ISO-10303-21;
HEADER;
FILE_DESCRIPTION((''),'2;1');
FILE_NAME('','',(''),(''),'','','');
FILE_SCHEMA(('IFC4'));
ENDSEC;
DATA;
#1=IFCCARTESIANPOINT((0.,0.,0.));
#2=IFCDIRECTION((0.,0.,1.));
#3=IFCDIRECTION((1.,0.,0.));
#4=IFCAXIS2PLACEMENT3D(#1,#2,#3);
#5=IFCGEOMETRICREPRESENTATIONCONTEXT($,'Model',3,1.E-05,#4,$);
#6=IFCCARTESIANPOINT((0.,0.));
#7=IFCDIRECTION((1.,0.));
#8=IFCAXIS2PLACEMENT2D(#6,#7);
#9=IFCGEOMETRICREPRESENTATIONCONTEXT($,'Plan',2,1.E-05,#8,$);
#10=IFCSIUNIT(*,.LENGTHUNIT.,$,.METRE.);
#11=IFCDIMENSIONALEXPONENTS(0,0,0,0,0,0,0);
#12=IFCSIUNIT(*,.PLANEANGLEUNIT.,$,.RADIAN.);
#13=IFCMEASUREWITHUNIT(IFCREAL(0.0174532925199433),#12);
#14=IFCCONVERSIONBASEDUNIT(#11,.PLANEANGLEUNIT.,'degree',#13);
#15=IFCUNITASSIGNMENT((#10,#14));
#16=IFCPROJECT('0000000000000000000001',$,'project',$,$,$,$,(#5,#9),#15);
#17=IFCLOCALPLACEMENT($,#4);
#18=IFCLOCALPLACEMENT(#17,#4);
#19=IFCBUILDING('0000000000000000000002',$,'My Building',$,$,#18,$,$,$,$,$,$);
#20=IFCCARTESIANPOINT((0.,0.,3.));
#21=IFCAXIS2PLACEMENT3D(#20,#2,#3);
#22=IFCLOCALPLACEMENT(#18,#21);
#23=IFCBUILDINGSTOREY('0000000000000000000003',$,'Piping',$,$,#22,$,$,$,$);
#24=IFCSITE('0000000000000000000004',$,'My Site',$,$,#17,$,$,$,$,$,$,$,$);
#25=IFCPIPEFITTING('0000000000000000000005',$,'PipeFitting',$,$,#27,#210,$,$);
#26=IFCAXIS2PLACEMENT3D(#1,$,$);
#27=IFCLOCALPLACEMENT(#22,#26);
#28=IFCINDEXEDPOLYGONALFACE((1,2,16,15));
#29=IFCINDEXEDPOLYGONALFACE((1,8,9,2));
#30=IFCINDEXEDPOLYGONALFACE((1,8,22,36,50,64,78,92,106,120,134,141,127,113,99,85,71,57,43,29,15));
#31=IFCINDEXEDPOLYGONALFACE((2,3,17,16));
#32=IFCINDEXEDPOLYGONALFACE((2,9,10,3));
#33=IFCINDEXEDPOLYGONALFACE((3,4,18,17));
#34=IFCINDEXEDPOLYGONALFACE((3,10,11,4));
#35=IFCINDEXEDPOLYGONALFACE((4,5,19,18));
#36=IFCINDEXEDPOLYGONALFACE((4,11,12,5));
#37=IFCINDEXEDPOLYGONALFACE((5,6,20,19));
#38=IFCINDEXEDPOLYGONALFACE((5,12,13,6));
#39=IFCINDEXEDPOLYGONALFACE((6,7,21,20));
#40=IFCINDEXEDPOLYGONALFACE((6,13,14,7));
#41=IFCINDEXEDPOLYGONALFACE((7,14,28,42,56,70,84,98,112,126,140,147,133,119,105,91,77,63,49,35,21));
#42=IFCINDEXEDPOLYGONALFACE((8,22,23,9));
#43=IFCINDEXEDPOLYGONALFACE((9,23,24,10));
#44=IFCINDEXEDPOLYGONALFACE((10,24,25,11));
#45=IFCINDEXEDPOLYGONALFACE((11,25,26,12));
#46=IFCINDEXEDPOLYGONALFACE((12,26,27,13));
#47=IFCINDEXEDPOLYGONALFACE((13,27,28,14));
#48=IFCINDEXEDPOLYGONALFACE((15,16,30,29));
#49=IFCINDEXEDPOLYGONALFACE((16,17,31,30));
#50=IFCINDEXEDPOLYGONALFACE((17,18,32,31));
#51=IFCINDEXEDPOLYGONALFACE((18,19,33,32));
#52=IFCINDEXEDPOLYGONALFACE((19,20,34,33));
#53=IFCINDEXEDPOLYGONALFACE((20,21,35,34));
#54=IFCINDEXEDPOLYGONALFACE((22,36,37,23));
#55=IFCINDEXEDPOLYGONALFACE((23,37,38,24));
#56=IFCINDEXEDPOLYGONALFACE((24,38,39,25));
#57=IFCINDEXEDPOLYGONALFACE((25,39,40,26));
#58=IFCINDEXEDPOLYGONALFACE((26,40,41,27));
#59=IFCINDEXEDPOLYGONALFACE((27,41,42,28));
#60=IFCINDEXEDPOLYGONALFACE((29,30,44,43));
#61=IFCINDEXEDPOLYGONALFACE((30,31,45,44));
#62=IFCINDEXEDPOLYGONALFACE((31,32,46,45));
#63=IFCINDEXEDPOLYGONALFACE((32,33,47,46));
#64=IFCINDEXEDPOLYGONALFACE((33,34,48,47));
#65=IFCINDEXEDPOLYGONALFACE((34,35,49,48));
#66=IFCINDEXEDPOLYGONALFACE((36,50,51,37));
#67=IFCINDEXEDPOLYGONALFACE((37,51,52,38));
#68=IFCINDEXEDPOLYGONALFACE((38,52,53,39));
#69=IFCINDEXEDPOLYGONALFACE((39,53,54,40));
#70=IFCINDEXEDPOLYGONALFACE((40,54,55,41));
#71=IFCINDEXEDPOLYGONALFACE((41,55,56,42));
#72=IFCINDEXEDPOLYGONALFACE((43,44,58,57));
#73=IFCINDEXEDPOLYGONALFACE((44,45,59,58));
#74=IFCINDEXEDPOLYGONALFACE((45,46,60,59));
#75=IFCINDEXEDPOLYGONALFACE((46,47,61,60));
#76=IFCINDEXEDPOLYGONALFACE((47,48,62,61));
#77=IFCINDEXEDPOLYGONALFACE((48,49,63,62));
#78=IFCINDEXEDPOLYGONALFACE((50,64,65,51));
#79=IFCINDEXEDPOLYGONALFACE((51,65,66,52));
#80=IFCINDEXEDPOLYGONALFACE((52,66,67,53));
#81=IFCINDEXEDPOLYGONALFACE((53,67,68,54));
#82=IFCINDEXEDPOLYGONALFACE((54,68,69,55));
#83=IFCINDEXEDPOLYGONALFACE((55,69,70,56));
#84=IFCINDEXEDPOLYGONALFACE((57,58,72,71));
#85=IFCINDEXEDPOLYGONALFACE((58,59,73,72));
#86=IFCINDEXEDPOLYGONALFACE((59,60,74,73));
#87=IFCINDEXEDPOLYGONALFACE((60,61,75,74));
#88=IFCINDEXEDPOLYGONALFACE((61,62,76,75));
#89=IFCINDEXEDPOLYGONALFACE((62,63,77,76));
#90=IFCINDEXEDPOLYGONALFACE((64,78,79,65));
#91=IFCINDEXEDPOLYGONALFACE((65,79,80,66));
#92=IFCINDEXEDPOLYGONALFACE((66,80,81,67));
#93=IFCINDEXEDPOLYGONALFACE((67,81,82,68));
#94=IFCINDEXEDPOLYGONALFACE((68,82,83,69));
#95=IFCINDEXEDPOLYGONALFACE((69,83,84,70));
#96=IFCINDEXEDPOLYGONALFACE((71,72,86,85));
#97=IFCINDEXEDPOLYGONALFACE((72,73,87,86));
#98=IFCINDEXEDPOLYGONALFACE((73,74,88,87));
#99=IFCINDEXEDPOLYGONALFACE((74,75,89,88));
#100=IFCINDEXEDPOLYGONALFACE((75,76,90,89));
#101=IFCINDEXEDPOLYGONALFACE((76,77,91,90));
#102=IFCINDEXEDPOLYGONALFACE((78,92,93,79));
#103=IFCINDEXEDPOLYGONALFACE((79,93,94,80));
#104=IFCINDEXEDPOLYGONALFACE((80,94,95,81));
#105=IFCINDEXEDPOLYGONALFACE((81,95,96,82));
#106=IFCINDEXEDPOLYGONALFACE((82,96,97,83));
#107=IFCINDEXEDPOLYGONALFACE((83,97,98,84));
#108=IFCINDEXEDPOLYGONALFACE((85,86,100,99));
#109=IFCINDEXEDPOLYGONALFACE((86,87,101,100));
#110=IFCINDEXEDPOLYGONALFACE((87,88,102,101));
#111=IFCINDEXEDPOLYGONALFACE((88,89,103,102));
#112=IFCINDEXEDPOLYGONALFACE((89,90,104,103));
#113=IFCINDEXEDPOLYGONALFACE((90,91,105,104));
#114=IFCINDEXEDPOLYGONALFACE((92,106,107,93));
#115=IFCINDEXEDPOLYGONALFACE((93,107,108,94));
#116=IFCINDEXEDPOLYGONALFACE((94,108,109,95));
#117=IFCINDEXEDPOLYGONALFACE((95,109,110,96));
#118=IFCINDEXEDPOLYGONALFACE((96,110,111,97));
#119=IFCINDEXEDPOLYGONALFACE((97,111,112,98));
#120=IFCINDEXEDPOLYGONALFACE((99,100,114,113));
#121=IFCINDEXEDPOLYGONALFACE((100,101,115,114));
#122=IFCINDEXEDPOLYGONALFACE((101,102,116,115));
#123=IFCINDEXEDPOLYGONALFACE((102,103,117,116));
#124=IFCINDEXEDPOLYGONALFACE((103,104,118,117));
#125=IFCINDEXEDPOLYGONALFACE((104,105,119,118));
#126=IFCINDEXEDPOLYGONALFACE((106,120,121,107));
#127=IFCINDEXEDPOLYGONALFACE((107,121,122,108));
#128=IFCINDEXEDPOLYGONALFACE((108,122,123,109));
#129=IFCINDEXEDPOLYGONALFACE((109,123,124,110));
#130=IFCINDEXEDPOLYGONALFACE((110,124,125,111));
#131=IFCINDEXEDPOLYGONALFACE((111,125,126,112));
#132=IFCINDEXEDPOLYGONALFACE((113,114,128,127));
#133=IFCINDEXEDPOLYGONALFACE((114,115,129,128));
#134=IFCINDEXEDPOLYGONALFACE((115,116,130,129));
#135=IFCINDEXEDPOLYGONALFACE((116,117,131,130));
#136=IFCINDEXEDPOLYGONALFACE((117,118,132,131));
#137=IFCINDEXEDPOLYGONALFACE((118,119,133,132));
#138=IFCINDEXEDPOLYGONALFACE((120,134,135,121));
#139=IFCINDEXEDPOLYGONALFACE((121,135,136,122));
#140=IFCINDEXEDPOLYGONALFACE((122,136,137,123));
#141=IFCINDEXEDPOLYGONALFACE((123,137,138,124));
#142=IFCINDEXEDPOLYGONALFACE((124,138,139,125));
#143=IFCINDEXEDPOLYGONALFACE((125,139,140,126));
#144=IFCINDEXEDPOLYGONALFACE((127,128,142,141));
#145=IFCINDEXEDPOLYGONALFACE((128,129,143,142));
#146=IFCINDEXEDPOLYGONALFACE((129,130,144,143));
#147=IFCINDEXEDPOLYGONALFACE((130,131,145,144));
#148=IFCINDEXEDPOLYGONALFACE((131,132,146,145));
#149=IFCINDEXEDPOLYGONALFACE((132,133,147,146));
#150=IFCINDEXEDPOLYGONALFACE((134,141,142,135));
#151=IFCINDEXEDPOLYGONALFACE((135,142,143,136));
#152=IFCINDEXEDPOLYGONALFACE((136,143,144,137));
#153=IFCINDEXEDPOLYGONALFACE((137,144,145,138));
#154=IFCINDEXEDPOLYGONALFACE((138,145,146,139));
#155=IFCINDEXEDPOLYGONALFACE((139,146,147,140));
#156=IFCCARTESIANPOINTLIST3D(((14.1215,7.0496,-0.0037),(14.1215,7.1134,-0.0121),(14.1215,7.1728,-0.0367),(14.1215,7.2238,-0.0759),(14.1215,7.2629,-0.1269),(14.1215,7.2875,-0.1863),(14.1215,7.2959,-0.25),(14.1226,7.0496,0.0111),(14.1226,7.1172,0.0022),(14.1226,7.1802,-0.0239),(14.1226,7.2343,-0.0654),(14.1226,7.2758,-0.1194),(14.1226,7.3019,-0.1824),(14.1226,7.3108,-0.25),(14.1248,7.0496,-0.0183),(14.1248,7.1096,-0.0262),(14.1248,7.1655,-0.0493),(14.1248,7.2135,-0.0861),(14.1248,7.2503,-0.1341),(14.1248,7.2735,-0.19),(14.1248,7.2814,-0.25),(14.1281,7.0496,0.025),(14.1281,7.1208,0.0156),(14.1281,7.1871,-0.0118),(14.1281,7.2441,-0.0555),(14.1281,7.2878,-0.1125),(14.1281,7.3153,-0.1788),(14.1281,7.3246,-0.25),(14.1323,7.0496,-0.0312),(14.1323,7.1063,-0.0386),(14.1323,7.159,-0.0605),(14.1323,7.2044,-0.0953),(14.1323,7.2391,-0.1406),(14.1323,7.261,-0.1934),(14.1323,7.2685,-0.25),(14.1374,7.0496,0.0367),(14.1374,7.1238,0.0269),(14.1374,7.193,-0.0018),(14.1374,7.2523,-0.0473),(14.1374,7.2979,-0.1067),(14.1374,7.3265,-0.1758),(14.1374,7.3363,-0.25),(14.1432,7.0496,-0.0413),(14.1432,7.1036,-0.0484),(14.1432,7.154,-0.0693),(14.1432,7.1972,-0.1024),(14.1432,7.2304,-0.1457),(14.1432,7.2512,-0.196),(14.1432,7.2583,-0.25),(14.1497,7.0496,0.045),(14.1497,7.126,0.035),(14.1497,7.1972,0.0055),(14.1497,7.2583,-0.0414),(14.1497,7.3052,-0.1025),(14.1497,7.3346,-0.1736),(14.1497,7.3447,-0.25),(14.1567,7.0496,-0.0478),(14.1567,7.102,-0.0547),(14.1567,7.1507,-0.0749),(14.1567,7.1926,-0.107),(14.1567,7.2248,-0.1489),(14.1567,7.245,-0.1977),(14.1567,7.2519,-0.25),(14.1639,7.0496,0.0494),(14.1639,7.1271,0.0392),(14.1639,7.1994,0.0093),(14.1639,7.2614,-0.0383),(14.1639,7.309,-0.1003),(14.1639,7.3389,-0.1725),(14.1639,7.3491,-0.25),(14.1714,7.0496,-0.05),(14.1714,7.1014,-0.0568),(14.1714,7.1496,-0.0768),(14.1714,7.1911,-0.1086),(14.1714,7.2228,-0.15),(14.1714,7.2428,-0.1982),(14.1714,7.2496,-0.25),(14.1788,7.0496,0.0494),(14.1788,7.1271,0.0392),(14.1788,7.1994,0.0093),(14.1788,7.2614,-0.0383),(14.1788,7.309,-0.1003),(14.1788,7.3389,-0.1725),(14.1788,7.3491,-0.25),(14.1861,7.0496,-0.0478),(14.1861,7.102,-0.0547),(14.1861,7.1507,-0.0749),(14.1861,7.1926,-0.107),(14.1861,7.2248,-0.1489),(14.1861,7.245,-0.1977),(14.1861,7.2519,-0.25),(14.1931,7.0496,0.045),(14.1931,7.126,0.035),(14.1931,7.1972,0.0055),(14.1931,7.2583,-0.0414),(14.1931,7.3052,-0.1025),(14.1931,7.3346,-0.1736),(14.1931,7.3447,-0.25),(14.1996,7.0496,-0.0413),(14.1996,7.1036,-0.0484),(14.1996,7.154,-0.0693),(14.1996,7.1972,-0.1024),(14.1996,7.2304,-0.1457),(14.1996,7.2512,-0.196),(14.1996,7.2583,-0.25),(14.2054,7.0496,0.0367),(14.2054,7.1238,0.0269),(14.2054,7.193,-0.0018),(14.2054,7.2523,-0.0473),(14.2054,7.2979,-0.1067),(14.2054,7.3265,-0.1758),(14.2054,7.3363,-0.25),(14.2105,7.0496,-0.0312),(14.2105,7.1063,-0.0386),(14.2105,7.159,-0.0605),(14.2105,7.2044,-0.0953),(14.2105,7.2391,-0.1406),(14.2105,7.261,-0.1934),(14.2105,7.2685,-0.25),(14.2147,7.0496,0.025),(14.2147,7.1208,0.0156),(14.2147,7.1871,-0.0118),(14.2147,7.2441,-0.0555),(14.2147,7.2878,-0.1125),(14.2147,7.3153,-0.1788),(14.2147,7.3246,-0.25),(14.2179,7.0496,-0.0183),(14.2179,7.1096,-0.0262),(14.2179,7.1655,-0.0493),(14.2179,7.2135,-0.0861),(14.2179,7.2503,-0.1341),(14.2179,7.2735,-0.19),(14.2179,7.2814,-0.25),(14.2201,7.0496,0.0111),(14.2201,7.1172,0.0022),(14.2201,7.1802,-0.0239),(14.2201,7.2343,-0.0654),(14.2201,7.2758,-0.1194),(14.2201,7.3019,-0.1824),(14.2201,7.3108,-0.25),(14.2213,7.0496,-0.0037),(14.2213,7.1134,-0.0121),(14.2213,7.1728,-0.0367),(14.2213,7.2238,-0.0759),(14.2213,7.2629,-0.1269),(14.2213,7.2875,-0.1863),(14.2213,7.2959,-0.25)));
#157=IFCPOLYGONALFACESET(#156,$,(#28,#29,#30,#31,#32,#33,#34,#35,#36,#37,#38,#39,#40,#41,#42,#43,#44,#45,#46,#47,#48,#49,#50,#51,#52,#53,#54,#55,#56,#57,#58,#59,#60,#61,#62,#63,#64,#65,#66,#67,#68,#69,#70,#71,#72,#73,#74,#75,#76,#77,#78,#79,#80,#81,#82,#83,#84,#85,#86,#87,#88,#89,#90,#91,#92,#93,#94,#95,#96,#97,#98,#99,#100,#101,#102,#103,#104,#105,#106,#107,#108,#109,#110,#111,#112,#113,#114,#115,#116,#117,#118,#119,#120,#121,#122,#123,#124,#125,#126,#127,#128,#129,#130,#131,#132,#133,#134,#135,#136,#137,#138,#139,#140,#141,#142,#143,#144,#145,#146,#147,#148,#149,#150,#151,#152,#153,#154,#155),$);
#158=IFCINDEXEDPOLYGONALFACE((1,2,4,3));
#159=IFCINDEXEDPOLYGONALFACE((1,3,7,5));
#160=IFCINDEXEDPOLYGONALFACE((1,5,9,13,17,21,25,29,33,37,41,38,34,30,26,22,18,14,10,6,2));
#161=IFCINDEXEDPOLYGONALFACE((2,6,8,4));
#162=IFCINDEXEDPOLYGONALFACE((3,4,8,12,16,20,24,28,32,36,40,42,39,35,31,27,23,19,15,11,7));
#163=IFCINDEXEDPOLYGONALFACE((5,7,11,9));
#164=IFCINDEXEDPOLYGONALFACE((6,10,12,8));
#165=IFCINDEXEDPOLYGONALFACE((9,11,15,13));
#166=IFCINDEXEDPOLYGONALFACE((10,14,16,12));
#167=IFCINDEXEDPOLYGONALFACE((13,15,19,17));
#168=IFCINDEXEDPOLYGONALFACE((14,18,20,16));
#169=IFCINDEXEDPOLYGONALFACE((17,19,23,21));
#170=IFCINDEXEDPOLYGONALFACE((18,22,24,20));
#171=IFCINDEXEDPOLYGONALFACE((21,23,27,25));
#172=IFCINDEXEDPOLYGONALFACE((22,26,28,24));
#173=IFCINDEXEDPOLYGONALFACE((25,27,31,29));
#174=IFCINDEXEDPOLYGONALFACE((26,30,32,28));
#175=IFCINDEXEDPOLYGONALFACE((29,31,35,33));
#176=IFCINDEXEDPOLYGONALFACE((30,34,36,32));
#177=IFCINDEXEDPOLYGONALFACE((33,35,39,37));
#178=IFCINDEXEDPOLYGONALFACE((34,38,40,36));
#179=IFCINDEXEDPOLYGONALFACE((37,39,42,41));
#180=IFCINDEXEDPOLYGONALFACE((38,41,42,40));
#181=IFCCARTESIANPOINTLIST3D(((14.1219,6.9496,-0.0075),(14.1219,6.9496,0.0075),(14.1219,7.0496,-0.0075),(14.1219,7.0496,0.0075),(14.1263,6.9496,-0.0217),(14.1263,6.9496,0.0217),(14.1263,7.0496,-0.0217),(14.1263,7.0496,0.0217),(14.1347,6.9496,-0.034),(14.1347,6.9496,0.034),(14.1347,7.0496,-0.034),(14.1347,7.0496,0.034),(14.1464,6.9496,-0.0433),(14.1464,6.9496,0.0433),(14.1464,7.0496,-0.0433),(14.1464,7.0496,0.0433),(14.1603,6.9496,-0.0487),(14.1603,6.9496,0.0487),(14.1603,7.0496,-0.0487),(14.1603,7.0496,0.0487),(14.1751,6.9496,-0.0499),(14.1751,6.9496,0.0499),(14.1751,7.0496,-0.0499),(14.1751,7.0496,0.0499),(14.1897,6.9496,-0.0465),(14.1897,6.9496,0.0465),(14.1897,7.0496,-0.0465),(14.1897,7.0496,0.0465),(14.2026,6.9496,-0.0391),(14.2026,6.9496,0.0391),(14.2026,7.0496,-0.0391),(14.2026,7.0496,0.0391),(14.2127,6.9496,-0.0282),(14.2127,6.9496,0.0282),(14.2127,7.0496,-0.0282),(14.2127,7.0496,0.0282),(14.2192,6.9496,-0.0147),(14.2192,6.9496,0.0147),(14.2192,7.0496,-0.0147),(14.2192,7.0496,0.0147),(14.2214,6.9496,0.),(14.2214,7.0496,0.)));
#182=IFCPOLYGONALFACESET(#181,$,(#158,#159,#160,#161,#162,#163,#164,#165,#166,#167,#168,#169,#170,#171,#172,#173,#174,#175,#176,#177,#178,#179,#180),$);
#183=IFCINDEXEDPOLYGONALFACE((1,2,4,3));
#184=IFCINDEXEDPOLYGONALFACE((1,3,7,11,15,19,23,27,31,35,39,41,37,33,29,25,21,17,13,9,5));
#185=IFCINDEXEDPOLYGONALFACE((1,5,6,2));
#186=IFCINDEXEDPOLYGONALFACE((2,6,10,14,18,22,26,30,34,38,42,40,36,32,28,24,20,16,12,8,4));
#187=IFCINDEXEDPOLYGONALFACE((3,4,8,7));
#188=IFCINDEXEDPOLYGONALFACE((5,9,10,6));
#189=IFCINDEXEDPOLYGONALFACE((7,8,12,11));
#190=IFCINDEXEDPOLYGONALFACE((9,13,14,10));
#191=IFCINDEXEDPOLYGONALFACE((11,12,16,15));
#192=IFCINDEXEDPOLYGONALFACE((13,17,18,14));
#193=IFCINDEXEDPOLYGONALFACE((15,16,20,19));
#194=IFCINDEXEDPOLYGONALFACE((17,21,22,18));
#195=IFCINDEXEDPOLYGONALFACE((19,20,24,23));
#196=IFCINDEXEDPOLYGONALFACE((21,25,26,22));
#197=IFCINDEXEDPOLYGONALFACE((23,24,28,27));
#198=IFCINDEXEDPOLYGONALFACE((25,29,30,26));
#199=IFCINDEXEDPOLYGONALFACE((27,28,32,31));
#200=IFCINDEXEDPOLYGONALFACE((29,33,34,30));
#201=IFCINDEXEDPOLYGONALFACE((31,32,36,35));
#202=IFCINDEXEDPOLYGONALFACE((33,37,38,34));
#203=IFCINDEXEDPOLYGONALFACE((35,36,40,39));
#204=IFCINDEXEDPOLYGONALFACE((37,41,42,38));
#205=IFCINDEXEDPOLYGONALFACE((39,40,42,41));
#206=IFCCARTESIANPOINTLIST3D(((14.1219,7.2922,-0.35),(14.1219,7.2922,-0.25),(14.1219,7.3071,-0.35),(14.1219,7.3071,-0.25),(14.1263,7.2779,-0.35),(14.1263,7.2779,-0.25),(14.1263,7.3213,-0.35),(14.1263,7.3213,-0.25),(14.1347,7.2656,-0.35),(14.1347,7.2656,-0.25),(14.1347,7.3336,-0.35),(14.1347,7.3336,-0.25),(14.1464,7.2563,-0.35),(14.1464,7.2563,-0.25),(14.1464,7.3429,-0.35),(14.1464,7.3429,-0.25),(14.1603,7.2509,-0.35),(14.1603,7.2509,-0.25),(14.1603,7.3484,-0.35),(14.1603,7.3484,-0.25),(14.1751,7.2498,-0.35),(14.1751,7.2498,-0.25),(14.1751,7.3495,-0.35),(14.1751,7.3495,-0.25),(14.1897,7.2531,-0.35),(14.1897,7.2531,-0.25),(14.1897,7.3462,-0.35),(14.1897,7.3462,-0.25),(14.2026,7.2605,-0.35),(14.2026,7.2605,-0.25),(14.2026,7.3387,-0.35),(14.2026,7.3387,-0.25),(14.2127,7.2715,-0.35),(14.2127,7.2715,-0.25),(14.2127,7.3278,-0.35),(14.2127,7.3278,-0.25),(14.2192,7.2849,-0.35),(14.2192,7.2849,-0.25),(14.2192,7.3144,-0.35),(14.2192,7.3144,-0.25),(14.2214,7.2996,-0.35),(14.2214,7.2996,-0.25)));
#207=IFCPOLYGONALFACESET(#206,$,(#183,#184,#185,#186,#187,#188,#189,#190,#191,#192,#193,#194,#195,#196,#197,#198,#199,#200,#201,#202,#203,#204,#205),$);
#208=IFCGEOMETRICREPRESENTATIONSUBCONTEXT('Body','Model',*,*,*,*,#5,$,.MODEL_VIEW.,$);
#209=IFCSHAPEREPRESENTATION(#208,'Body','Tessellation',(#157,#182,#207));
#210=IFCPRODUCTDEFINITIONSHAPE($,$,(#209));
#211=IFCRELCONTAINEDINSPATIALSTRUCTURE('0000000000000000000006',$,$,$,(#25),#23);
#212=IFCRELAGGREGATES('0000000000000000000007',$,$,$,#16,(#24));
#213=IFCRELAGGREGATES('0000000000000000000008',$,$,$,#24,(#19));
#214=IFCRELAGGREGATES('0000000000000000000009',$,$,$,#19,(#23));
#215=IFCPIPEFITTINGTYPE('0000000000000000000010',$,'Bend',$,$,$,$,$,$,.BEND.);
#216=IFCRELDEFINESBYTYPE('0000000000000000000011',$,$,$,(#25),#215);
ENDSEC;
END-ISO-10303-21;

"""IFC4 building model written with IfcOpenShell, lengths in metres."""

from ifc_helpers import new_model, entity, si_unit, converted_unit, frame, origin_with_axes, origin_2d_with_axis, place, context, subcontext, project, spatial, circle, extrude, source, transform, mapped, type_object, type_shapes, element, save


model = new_model("IFC4")

# Units and contexts
model_context = context("Model", 3, precision=1e-05, world=origin_with_axes())
plan_context = context("Plan", 2, precision=1e-05, world=origin_2d_with_axis())
body_context = subcontext(model_context, "Body", "Model", "MODEL_VIEW")
ifc_project = project(units=[si_unit("LENGTHUNIT", "METRE"), converted_unit("PLANEANGLEUNIT", "degree", entity("IfcReal", 0.0174532925199433), si_unit("PLANEANGLEUNIT", "RADIAN"), dimensions=[0, 0, 0, 0, 0, 0, 0])], contexts=[model_context, plan_context])

# Site, building, storey
site_placement = place(None, origin_with_axes())
site = spatial("IfcSite", under=ifc_project, at=site_placement, Name="My Site")
building_placement = place(site_placement, origin_with_axes())
building = spatial("IfcBuilding", under=site, at=building_placement, Name="My Building")
storey_placement = place(building_placement, frame((0.0, 0.0, 3.0), z_axis=(0.0, 0.0, 1.0), x_axis=(1.0, 0.0, 0.0)))
storey = spatial("IfcBuildingStorey", under=building, at=storey_placement, Name="Piping")

# Pipe fitting
pipe_fitting_type = type_object("IfcPipeFittingType", Name="Bend", PredefinedType="BEND")
shared_shape = source(origin_with_axes(), body_context, "Body", "SolidModel", [
    entity("IfcSweptDiskSolid", entity("IfcIndexedPolyCurve", entity("IfcCartesianPointList3D", [[0.0, 0.0, -0.1], [0.0, -0.0732, -0.2768], [0.0, -0.25, -0.35]]), [entity("IfcArcIndex", [1, 2, 3])]), 0.05),
    extrude(circle(Radius=0.05), origin_with_axes(), (0.0, 0.0, -1.0), 0.1),
    extrude(circle(Radius=0.05), frame((0.0, -0.25, -0.35), z_axis=(0.0, -1.0, 0.0), x_axis=(1.0, 0.0, 0.0)), (0.0, 0.0, 1.0), 0.1),
])
type_shapes(pipe_fitting_type, [shared_shape])
for number, where, z_axis, x_axis, name in (
    (1, (14.1714, 6.9496, 0.0), (0.0, -1.0, 0.0), (1.0, 0.0, 0.0), "PipeFitting"),
):
    element("IfcPipeFitting", number, at=place(storey_placement, frame(where, z_axis=z_axis, x_axis=x_axis)), inside=storey, type_object=pipe_fitting_type, Name=name, context=body_context, shape_type="MappedRepresentation", body=[
        mapped(shared_shape, transform((0.0, 0.0, 0.0), x_axis=(1.0, 0.0, 0.0), y_axis=(0.0, 1.0, 0.0), z_axis=(0.0, 0.0, 1.0), scale=1.0)),
    ])

save(model, "model.ifc")
